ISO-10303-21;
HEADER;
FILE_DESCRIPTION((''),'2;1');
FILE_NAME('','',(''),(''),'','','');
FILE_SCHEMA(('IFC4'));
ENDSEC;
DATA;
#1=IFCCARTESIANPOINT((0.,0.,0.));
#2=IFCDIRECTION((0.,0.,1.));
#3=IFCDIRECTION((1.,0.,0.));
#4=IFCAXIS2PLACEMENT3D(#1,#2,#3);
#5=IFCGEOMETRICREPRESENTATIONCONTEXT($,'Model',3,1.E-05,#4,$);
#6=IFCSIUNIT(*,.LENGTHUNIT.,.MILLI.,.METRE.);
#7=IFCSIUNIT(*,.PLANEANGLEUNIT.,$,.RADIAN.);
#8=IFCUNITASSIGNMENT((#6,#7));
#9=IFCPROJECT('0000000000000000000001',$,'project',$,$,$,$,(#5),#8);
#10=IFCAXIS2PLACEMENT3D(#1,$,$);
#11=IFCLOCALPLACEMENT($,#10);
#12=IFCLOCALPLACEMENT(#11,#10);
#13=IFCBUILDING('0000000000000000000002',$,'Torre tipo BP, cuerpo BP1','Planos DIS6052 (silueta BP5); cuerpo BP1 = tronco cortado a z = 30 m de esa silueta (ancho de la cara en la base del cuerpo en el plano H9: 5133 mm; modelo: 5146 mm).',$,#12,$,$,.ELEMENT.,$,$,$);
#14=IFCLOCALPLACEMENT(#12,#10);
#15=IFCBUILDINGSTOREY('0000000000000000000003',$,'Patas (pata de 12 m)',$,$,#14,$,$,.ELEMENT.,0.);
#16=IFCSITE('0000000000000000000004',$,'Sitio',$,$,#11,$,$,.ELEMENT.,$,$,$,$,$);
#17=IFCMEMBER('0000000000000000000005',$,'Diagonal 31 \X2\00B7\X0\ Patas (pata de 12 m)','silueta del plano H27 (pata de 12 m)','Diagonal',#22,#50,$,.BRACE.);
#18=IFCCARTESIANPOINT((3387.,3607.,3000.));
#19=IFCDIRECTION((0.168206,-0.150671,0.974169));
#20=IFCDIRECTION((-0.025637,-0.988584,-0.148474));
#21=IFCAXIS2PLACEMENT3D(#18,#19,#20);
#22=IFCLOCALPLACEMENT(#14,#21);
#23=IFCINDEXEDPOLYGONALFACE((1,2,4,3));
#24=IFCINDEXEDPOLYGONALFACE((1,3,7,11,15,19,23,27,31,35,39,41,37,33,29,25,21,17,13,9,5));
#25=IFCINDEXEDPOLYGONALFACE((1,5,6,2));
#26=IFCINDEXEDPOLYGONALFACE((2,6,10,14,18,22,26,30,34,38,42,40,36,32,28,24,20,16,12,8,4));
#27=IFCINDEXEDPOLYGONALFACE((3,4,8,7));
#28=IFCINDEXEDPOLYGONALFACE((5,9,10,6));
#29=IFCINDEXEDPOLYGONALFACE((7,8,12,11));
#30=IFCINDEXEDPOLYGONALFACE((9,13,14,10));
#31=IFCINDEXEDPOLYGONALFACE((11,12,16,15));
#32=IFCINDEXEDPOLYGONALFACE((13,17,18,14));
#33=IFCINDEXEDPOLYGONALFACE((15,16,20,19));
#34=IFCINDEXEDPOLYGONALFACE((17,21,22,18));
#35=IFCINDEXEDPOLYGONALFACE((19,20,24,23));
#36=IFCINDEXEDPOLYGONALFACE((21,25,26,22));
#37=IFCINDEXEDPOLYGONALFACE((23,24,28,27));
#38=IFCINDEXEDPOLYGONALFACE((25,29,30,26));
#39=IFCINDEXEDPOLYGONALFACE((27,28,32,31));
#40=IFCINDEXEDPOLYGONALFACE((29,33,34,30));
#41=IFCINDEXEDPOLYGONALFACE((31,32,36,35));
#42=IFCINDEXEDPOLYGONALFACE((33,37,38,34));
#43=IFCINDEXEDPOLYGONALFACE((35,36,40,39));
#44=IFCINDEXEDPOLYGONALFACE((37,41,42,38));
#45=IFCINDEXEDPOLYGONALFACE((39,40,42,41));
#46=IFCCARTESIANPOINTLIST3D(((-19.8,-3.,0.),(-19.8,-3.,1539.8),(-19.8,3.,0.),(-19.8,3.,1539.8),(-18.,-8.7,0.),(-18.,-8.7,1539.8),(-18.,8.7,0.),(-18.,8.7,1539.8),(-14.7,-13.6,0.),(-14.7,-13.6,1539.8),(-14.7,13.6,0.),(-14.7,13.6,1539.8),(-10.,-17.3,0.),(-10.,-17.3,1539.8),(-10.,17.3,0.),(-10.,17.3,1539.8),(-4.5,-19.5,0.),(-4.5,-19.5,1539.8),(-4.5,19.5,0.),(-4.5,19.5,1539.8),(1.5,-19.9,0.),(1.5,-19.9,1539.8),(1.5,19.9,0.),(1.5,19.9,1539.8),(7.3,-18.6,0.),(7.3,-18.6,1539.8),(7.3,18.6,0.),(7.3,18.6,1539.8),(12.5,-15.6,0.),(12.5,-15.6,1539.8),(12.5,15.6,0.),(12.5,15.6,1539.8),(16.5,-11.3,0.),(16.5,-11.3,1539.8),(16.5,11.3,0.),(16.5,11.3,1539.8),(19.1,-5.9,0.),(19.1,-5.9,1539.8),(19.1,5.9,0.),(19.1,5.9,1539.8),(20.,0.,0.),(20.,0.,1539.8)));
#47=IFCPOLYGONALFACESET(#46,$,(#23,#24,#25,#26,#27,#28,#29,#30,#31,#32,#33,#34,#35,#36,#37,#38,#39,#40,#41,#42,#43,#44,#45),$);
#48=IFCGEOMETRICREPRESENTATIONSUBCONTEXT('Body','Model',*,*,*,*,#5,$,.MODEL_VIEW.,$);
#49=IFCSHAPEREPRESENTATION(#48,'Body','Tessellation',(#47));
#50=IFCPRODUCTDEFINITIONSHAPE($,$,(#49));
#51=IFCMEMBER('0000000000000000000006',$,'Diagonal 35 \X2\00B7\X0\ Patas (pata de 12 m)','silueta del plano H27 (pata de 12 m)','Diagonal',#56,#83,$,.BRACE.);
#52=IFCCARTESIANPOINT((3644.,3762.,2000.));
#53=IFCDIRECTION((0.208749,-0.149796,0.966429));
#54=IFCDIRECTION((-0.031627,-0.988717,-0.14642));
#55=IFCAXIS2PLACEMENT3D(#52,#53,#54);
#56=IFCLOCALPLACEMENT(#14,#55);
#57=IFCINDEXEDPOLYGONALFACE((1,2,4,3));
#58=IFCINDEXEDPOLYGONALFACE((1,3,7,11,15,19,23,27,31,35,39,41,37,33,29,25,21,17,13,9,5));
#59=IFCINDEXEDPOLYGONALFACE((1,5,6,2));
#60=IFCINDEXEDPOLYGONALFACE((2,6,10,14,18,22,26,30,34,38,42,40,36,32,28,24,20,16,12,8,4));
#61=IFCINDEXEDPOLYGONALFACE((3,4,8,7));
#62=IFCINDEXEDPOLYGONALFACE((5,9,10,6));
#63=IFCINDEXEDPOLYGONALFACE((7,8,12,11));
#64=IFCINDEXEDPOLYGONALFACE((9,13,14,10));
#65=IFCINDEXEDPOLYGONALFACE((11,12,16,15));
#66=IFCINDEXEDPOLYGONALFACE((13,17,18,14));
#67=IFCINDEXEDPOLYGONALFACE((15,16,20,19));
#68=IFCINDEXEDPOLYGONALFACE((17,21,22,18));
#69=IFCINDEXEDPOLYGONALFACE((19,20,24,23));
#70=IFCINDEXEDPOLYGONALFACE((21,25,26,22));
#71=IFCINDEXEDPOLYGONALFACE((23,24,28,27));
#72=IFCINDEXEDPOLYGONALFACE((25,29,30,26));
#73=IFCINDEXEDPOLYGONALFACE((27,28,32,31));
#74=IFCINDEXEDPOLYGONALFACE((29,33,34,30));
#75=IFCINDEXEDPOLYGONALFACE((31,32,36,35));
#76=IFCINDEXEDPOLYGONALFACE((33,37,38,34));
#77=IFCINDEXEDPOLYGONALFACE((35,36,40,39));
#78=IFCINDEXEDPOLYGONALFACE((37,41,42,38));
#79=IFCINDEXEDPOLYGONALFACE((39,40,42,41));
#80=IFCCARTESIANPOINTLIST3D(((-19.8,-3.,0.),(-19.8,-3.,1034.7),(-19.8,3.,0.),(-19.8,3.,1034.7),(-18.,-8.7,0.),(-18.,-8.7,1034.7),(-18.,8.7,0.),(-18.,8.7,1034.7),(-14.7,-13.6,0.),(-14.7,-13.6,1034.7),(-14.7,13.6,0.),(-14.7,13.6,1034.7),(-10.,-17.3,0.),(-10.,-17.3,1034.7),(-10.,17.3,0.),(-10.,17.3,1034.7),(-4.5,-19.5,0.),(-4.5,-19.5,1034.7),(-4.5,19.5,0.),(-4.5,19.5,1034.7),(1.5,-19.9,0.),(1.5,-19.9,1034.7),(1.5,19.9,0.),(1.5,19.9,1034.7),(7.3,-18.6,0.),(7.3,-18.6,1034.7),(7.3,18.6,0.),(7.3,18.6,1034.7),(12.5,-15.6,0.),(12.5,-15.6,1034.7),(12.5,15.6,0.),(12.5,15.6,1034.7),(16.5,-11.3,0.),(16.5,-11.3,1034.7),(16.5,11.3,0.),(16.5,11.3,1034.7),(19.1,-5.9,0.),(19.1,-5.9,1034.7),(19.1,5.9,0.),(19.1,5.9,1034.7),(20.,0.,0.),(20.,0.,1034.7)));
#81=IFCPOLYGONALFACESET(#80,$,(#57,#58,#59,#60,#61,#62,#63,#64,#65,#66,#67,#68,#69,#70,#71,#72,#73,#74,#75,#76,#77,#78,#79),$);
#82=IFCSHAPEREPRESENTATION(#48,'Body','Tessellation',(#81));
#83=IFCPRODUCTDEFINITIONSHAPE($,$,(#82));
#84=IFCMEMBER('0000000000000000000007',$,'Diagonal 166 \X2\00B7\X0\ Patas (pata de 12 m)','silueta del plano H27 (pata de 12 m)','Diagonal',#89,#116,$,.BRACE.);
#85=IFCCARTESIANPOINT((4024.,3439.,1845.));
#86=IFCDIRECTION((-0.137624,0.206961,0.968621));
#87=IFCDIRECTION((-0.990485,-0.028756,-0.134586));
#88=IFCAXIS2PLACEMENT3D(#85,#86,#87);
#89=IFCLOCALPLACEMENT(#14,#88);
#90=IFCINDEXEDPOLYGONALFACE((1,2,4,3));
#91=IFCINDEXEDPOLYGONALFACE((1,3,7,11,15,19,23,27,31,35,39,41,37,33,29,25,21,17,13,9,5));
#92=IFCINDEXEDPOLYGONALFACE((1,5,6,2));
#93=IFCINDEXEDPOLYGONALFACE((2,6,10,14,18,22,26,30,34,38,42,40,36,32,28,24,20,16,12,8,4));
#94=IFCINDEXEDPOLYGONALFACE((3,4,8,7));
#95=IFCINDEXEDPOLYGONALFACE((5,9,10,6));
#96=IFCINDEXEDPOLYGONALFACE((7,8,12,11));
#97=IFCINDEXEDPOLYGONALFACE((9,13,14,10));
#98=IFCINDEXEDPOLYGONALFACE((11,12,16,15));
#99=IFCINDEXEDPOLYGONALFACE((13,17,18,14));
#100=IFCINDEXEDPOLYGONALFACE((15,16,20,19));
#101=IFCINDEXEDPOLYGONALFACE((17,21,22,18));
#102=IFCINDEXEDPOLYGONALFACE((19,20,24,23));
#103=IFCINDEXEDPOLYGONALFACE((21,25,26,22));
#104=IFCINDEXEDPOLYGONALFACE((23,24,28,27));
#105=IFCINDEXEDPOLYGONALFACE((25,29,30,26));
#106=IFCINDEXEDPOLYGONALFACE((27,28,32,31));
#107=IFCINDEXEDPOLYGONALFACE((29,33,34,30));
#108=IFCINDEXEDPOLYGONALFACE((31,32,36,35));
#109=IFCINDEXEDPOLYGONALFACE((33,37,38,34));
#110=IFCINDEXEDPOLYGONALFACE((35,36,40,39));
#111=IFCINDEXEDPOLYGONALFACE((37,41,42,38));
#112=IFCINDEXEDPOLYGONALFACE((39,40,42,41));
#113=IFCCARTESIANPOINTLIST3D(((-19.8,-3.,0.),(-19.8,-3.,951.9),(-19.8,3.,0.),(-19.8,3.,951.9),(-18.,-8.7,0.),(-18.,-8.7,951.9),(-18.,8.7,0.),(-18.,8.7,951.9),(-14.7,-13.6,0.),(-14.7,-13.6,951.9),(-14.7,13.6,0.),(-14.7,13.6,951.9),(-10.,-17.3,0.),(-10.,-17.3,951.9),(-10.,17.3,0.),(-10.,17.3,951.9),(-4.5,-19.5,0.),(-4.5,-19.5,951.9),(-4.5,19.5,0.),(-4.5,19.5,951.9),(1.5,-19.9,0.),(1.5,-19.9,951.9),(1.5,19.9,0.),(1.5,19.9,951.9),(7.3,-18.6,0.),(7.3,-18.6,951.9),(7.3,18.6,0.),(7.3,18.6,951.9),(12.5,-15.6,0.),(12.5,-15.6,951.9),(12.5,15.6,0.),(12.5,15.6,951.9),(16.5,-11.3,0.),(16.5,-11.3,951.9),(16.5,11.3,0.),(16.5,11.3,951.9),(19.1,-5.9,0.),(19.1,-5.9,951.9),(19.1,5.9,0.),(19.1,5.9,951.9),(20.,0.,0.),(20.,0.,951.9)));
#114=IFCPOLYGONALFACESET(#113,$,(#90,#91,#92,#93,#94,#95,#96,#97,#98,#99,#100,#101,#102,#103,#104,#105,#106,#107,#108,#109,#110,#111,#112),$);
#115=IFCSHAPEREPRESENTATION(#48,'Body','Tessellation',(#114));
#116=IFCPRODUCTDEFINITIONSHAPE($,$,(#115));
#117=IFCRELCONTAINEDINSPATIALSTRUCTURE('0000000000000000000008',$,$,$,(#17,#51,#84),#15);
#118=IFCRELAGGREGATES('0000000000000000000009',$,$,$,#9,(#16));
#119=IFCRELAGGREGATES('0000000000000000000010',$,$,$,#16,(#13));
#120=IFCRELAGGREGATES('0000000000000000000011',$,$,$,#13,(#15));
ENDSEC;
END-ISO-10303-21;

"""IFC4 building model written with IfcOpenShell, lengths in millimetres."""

from ifc_helpers import new_model, si_unit, frame, origin, origin_with_axes, place, context, subcontext, project, spatial, circle, extrude, element, save


model = new_model("IFC4")

# Units and contexts
model_context = context("Model", 3, precision=1e-05, world=origin_with_axes())
body_context = subcontext(model_context, "Body", "Model", "MODEL_VIEW")
ifc_project = project(units=[si_unit("LENGTHUNIT", "METRE", prefix="MILLI"), si_unit("PLANEANGLEUNIT", "RADIAN")], contexts=[model_context])

# Site, building, storey
site_placement = place(None, origin())
site = spatial("IfcSite", under=ifc_project, at=site_placement, Name="Sitio", CompositionType="ELEMENT")
building_placement = place(site_placement, origin())
building = spatial("IfcBuilding", under=site, at=building_placement, Name="Torre tipo BP, cuerpo BP1", Description="Planos DIS6052 (silueta BP5); cuerpo BP1 = tronco cortado a z = 30 m de esa silueta (ancho de la cara en la base del cuerpo en el plano H9: 5133 mm; modelo: 5146 mm).", CompositionType="ELEMENT")
storey_placement = place(building_placement, origin())
storey = spatial("IfcBuildingStorey", under=building, at=storey_placement, Name="Patas (pata de 12 m)", CompositionType="ELEMENT", Elevation=0.0)

# Members
member_1_placement = place(storey_placement, frame((3387.0, 3607.0, 3000.0), z_axis=(0.168206, -0.150671, 0.974169), x_axis=(-0.025637, -0.988584, -0.148474)))
element("IfcMember", 1, at=member_1_placement, inside=storey, Name="Diagonal 31 · Patas (pata de 12 m)", Description="silueta del plano H27 (pata de 12 m)", ObjectType="Diagonal", PredefinedType="BRACE", context=body_context, shape_type="SweptSolid", body=[
    extrude(circle(Radius=20.0), None, (0.0, 0.0, 1.0), 1539.8),
])
member_2_placement = place(storey_placement, frame((3644.0, 3762.0, 2000.0), z_axis=(0.208749, -0.149796, 0.966429), x_axis=(-0.031627, -0.988717, -0.14642)))
element("IfcMember", 2, at=member_2_placement, inside=storey, Name="Diagonal 35 · Patas (pata de 12 m)", Description="silueta del plano H27 (pata de 12 m)", ObjectType="Diagonal", PredefinedType="BRACE", context=body_context, shape_type="SweptSolid", body=[
    extrude(circle(Radius=20.0), None, (0.0, 0.0, 1.0), 1034.7),
])
member_3_placement = place(storey_placement, frame((4024.0, 3439.0, 1845.0), z_axis=(-0.137624, 0.206961, 0.968621), x_axis=(-0.990485, -0.028756, -0.134586)))
element("IfcMember", 3, at=member_3_placement, inside=storey, Name="Diagonal 166 · Patas (pata de 12 m)", Description="silueta del plano H27 (pata de 12 m)", ObjectType="Diagonal", PredefinedType="BRACE", context=body_context, shape_type="SweptSolid", body=[
    extrude(circle(Radius=20.0), None, (0.0, 0.0, 1.0), 951.9),
])

save(model, "model.ifc")
